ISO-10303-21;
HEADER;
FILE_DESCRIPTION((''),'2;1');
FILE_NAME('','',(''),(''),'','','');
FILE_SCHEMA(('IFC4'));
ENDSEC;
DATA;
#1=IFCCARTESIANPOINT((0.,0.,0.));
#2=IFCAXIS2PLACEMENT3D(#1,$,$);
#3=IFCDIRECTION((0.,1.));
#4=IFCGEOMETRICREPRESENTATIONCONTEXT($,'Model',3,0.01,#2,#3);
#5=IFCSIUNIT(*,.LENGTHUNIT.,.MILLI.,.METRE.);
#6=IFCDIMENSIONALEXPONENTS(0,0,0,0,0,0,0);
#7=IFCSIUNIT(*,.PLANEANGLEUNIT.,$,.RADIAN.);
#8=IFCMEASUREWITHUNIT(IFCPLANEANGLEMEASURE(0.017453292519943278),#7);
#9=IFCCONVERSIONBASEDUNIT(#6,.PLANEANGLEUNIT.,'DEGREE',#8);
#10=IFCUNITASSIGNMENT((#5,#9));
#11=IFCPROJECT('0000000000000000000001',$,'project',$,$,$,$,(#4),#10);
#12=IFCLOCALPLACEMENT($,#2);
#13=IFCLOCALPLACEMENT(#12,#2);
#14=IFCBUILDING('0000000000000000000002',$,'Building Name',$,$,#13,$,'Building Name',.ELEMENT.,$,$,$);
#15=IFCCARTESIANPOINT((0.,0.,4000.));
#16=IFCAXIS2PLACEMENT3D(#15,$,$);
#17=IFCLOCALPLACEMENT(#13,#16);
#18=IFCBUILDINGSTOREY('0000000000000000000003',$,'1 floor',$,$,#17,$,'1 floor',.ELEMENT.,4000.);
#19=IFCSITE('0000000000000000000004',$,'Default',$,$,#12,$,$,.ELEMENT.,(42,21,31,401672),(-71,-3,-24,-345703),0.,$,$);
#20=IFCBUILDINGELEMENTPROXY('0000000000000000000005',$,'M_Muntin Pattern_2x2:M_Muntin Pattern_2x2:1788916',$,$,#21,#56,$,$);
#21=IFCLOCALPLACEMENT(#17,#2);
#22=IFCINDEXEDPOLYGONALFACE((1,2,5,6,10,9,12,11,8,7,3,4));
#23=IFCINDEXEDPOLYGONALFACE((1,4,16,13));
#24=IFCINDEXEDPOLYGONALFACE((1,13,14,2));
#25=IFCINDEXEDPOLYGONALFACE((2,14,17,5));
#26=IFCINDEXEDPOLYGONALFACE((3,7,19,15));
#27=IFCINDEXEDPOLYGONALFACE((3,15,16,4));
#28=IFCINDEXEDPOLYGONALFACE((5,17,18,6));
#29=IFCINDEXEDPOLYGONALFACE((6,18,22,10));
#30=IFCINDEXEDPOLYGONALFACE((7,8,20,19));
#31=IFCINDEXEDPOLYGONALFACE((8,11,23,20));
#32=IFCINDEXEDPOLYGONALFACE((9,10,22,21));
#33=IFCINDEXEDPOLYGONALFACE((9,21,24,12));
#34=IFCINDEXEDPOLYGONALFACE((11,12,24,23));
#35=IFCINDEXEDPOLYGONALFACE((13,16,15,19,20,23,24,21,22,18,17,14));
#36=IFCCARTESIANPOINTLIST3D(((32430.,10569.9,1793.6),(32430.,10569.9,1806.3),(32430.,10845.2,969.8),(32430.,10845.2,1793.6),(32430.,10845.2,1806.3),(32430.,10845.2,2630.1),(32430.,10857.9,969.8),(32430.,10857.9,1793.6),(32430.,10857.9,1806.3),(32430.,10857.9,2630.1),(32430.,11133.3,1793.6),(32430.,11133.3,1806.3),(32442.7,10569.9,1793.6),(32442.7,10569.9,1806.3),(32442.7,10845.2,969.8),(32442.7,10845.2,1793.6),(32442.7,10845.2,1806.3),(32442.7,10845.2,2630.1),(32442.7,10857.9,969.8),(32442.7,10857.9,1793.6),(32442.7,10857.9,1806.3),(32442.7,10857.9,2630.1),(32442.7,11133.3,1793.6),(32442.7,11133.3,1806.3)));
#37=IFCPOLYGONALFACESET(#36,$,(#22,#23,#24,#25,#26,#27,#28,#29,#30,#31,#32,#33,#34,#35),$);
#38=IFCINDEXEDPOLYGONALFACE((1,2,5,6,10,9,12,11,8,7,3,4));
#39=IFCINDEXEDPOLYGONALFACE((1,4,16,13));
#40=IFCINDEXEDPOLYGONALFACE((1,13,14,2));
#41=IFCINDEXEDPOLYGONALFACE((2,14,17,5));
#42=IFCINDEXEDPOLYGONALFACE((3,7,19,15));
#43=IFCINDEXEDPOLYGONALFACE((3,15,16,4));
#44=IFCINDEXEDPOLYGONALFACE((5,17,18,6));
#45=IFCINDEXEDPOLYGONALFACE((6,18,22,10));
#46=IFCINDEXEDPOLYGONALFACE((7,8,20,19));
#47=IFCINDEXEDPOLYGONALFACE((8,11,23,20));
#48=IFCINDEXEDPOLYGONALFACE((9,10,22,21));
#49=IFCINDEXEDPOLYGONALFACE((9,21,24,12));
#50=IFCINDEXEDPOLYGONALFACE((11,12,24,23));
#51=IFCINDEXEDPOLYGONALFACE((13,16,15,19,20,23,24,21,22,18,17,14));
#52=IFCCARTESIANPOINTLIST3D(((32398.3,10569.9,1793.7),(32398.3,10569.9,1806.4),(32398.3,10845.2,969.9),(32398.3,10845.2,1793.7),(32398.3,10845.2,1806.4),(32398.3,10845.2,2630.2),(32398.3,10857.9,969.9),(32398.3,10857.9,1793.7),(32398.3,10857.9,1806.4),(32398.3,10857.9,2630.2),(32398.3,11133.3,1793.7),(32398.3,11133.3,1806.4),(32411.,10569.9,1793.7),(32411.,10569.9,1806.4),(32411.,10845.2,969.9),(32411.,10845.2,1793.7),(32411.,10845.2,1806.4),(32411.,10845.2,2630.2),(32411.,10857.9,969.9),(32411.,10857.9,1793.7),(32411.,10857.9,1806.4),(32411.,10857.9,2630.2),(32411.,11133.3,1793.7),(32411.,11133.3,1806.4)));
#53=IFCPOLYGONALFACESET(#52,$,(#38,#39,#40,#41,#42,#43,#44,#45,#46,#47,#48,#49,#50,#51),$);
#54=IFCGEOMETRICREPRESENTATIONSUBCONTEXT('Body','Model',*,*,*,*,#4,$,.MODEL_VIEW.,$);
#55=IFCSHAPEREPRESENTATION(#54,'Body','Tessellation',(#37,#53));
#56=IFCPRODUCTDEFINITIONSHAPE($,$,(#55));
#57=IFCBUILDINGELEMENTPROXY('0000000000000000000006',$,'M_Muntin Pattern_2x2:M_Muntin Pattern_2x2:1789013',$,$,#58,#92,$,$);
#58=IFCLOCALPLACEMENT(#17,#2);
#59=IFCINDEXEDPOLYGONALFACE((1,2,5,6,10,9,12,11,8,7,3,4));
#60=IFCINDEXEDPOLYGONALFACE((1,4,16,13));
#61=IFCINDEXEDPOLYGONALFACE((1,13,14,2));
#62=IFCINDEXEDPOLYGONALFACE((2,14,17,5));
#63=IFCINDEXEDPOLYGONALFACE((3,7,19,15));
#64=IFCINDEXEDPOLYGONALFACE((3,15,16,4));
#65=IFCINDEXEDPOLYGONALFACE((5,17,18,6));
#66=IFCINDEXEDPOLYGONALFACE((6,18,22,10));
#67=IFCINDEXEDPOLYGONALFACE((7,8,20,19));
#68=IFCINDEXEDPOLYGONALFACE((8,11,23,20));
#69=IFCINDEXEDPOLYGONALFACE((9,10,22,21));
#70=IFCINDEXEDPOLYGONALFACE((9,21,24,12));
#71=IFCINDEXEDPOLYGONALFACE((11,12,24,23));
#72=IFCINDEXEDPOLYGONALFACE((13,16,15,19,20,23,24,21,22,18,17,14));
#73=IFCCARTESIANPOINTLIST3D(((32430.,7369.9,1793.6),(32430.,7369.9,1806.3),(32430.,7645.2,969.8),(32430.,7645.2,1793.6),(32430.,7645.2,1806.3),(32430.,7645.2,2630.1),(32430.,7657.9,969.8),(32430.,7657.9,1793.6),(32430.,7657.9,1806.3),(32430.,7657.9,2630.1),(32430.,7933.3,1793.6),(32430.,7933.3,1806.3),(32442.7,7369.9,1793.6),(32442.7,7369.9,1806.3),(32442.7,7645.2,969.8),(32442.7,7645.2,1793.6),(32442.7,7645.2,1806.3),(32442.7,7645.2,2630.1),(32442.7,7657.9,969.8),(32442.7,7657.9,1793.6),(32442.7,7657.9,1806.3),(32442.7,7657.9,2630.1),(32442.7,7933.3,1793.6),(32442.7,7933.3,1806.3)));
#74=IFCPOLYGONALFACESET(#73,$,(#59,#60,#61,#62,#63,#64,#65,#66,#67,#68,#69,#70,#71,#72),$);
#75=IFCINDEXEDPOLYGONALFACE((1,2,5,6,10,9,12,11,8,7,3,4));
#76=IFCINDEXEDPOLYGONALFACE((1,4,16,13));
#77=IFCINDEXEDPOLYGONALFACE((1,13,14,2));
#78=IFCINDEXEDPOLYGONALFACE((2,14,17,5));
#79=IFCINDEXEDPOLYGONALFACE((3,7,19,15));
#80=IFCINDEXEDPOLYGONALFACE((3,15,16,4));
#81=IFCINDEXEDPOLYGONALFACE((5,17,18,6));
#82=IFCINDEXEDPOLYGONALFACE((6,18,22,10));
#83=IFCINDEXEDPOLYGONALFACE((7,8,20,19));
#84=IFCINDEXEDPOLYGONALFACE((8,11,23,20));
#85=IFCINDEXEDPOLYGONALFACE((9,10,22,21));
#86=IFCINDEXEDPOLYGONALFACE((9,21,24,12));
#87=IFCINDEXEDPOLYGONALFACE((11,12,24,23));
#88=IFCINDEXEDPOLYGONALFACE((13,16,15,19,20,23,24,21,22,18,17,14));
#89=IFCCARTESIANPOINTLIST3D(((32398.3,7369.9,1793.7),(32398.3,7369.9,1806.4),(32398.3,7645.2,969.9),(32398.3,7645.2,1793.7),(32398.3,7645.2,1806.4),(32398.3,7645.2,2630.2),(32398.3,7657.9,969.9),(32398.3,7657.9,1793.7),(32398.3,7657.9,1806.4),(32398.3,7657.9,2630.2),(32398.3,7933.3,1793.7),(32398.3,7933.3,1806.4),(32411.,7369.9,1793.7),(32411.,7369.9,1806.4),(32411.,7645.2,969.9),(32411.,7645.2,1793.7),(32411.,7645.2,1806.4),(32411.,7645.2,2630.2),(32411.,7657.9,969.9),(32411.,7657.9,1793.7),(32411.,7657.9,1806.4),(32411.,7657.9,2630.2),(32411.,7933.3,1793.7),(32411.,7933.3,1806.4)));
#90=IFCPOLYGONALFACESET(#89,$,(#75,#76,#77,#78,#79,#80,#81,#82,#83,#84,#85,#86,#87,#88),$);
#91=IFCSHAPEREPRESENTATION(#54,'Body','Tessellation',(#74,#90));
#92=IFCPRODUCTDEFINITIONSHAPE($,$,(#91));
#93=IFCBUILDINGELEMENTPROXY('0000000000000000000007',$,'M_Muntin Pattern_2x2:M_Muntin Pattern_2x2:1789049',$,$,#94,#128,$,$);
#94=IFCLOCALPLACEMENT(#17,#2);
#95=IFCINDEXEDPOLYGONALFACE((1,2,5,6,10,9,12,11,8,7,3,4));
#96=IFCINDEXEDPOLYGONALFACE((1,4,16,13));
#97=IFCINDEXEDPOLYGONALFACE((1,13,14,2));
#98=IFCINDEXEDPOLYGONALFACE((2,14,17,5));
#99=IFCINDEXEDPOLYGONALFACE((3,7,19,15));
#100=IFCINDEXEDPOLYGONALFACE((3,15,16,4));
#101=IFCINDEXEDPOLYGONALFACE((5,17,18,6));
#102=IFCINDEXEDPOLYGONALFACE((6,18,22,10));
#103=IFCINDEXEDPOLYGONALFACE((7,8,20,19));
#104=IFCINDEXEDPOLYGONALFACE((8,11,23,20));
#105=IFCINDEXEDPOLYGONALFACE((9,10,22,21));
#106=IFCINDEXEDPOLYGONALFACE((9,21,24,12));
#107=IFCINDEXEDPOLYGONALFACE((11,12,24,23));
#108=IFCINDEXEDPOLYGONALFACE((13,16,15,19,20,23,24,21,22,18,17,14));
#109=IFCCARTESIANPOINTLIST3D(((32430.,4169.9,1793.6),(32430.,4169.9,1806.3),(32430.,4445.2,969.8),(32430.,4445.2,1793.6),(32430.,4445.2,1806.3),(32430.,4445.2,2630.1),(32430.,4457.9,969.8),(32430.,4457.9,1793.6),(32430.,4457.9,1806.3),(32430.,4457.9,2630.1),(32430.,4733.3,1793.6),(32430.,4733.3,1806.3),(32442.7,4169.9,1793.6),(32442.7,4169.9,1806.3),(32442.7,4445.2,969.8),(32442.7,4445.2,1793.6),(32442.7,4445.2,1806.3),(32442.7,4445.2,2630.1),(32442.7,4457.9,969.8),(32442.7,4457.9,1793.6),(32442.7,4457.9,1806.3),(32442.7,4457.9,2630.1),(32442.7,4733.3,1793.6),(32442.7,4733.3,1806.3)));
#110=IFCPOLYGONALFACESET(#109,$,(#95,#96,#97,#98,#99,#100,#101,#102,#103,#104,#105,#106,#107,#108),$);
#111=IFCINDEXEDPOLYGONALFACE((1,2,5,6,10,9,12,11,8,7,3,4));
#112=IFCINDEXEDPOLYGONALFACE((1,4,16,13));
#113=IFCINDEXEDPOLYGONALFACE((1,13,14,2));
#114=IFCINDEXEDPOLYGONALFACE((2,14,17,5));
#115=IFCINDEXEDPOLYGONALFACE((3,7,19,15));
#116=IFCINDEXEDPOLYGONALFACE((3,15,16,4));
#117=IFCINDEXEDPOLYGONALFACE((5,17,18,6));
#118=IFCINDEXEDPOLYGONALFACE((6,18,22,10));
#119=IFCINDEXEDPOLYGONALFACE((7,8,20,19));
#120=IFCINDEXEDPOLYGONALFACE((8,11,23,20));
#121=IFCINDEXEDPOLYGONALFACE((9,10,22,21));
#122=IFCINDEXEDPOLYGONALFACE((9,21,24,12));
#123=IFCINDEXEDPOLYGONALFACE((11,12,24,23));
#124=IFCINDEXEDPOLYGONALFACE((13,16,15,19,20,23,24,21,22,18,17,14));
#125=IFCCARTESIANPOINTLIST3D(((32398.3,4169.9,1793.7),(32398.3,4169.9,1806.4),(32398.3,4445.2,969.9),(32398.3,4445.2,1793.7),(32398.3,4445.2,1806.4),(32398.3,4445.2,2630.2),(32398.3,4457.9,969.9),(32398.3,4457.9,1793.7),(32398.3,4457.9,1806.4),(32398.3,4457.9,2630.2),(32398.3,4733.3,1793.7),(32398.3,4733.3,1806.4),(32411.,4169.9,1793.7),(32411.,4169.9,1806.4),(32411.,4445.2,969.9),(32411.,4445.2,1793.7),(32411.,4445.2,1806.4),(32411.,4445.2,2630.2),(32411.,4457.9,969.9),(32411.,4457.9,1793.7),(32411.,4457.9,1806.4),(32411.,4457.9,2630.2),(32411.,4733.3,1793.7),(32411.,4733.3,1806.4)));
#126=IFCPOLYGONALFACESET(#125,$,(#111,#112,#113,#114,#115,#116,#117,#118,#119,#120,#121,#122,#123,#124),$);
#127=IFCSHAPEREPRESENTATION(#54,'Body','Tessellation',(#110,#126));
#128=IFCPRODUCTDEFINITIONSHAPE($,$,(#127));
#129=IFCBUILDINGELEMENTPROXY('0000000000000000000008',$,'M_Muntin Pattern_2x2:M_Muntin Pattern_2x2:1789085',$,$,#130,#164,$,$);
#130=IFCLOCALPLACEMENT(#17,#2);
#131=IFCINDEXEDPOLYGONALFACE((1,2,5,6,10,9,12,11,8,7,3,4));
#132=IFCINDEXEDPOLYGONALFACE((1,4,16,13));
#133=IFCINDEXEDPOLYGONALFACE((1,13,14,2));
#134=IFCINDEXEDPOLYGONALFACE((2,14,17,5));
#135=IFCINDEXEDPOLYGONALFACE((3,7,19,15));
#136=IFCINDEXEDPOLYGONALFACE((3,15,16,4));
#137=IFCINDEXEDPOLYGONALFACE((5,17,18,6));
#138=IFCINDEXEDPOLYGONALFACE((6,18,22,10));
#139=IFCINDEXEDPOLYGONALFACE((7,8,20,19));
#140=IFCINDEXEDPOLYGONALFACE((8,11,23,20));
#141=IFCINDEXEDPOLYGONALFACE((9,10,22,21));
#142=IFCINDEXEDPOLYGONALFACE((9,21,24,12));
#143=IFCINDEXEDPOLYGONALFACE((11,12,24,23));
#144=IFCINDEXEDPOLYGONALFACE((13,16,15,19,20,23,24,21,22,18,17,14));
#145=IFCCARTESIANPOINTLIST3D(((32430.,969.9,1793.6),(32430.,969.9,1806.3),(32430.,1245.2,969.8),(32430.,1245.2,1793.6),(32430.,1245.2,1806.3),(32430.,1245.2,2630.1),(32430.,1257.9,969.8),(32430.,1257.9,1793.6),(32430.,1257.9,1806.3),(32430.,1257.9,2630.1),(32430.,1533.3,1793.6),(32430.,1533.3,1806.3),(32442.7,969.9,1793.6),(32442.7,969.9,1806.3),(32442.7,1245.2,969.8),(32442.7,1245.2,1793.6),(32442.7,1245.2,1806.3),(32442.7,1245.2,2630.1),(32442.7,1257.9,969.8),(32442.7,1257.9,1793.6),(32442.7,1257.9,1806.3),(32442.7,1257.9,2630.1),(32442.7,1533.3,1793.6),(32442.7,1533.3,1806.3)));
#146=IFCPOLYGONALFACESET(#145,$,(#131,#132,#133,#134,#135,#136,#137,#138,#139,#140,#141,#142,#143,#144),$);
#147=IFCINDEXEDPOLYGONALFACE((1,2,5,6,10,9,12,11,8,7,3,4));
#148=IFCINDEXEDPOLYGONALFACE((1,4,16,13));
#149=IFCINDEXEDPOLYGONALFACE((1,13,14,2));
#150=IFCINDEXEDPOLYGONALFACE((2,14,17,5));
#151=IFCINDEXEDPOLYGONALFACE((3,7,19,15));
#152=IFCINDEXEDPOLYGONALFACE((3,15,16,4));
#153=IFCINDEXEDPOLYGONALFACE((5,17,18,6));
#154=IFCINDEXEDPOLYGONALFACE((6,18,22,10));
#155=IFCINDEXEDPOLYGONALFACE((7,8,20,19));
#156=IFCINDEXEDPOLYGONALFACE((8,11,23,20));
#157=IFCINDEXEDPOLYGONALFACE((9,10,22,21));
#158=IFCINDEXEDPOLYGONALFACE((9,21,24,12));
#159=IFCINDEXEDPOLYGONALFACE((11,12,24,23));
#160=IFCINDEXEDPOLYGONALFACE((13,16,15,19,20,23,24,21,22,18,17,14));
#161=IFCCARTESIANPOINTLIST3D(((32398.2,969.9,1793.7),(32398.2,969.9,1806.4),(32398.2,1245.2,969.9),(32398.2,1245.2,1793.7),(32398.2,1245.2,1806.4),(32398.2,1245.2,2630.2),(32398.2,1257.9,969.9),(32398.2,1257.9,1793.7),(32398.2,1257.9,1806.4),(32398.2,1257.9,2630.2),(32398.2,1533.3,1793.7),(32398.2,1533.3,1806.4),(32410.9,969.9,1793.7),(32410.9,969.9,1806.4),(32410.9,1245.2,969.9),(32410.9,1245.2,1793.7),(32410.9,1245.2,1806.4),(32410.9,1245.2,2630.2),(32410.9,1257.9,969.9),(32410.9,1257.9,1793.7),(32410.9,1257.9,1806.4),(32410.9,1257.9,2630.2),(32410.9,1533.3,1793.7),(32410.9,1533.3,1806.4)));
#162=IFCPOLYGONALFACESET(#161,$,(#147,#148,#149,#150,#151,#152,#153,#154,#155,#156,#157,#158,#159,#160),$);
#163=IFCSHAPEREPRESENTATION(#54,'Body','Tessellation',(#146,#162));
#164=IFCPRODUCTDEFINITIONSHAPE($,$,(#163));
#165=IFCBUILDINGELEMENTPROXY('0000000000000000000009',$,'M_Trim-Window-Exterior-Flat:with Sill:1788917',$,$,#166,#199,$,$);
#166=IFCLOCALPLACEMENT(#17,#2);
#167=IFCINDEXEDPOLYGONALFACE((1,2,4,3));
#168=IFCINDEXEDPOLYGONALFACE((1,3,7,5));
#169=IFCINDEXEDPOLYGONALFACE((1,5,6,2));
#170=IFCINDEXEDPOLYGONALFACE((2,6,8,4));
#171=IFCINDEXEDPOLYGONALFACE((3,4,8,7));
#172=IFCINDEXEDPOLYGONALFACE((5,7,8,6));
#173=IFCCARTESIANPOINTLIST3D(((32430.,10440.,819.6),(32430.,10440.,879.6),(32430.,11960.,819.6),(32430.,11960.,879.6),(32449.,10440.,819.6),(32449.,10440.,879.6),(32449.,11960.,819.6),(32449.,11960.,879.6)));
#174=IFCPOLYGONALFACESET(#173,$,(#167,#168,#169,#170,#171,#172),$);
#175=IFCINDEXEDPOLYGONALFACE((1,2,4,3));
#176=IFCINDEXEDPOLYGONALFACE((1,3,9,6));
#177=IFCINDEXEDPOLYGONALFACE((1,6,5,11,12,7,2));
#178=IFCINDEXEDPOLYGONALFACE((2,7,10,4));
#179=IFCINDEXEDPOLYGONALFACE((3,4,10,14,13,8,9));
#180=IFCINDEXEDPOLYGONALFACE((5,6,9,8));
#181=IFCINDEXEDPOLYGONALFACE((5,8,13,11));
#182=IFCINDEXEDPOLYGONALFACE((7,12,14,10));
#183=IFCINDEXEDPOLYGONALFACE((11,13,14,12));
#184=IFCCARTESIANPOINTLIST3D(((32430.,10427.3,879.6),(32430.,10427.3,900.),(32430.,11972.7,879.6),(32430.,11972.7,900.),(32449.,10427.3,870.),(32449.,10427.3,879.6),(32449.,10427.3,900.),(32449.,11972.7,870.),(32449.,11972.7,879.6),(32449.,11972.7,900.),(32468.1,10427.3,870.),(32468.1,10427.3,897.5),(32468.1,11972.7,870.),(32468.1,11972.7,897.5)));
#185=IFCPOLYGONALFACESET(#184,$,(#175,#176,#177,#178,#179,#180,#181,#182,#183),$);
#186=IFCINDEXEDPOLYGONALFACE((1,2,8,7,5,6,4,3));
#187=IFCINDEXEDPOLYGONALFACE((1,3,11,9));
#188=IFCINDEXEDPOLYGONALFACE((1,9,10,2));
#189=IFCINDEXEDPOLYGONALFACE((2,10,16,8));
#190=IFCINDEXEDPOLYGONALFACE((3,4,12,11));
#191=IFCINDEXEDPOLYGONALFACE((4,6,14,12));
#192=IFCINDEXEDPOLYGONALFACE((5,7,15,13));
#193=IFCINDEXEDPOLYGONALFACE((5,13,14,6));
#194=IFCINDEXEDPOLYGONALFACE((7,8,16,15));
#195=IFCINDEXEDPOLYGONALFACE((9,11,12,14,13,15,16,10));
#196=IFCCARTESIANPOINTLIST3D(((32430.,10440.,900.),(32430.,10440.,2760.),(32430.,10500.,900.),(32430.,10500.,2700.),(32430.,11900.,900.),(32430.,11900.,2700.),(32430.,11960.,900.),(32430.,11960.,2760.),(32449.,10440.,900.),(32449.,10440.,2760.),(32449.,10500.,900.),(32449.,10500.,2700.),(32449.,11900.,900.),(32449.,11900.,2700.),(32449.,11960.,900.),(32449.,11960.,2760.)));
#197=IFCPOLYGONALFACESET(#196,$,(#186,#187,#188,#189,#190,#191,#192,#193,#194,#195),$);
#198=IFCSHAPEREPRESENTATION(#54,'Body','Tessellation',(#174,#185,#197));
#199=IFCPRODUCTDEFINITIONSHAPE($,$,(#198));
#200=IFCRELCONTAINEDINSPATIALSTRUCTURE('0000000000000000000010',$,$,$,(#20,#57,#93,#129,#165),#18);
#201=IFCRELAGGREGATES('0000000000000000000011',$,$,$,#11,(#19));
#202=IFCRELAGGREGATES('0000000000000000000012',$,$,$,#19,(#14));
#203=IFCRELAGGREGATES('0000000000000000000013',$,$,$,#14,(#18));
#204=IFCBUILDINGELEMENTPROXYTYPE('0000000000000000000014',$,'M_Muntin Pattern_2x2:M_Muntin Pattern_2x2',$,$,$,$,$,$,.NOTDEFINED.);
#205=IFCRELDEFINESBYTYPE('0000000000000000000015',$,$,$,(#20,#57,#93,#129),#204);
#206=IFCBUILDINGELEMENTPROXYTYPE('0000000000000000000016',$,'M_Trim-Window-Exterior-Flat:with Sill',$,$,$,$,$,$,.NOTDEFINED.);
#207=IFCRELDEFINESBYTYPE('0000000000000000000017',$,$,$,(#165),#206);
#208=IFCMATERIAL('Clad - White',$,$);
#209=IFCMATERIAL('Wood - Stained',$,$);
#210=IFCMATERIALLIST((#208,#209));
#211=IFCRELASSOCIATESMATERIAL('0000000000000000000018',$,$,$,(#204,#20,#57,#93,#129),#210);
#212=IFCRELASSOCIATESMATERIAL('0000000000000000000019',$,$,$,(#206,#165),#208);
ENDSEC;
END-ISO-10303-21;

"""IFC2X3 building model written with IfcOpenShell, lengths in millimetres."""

from ifc_helpers import new_model, entity, si_unit, converted_unit, direction, frame, frame_2d, origin, place, context, subcontext, project, spatial, polyline, rectangle, outline, extrude, source, transform, mapped, material, material_list, type_object, type_shapes, element, save


model = new_model("IFC2X3")

# Units and contexts
model_context = context("Model", 3, precision=0.01, world=origin(), true_north=direction((0.0, 1.0)))
body_context = subcontext(model_context, "Body", "Model", "MODEL_VIEW")
ifc_project = project(units=[si_unit("LENGTHUNIT", "METRE", prefix="MILLI"), converted_unit("PLANEANGLEUNIT", "DEGREE", entity("IfcPlaneAngleMeasure", 0.017453292519943278), si_unit("PLANEANGLEUNIT", "RADIAN"), dimensions=[0, 0, 0, 0, 0, 0, 0])], contexts=[model_context])

# Site, building, storey
site_placement = place(None, origin())
site = spatial("IfcSite", under=ifc_project, at=site_placement, Name="Default", CompositionType="ELEMENT", RefLatitude=(42, 21, 31, 401672), RefLongitude=(-71, -3, -24, -345703), RefElevation=0.0)
building_placement = place(site_placement, origin())
building = spatial("IfcBuilding", under=site, at=building_placement, Name="Building Name", LongName="Building Name", CompositionType="ELEMENT")
storey_placement = place(building_placement, frame((0.0, 0.0, 4000.0)))
storey = spatial("IfcBuildingStorey", under=building, at=storey_placement, Name="1 floor", LongName="1 floor", CompositionType="ELEMENT", Elevation=4000.0)

# Building element proxies
ifc_material_1 = material(Name="Clad - White")
ifc_material_2 = material(Name="Wood - Stained")
ifc_material_list = material_list([ifc_material_1, ifc_material_2])
building_element_proxy_type_1 = type_object("IfcBuildingElementProxyType", Name="M_Muntin Pattern_2x2:M_Muntin Pattern_2x2", PredefinedType="NOTDEFINED", material=ifc_material_list)
shared_shape_1 = source(origin(), body_context, "Body", "SweptSolid", [
    extrude(outline(polyline([(6.4, -6.4), (830.1, -6.4), (830.1, 6.3), (6.4, 6.3), (6.4, 281.7), (-6.3, 281.7), (-6.3, 6.3), (-830.2, 6.3), (-830.2, -6.4), (-6.3, -6.4), (-6.3, -281.7), (6.4, -281.7), (6.4, -6.4)])), frame((0.0, -22.2, 830.1), z_axis=(0.0, 1.0, 0.0), x_axis=(0.0, 0.0, 1.0)), (0.0, 0.0, 1.0), 12.7),
    extrude(outline(polyline([(6.4, -6.4), (830.2, -6.4), (830.2, 6.3), (6.4, 6.3), (6.4, 281.7), (-6.3, 281.7), (-6.3, 6.3), (-830.2, 6.3), (-830.2, -6.4), (-6.3, -6.4), (-6.3, -281.7), (6.4, -281.7), (6.4, -6.4)])), frame((0.0, 9.5, 830.2), z_axis=(0.0, 1.0, 0.0), x_axis=(0.0, 0.0, 1.0)), (0.0, 0.0, 1.0), 12.7),
])
type_shapes(building_element_proxy_type_1, [shared_shape_1])
for number, where, z_axis, x_axis, name in (
    (1, (32420.5, 10851.6, 969.9), (0.0, 0.0, 1.0), (0.0, 1.0, 0.0), "M_Muntin Pattern_2x2:M_Muntin Pattern_2x2:1788916"),
    (2, (32420.5, 7651.6, 969.9), (0.0, 0.0, 1.0), (0.0, 1.0, 0.0), "M_Muntin Pattern_2x2:M_Muntin Pattern_2x2:1789013"),
    (3, (32420.5, 4451.6, 969.9), (0.0, 0.0, 1.0), (0.0, 1.0, 0.0), "M_Muntin Pattern_2x2:M_Muntin Pattern_2x2:1789049"),
    (4, (32420.5, 1251.6, 969.9), (0.0, 0.0, 1.0), (0.0, 1.0, 0.0), "M_Muntin Pattern_2x2:M_Muntin Pattern_2x2:1789085"),
):
    element("IfcBuildingElementProxy", number, at=place(storey_placement, frame(where, z_axis=z_axis, x_axis=x_axis)), inside=storey, type_object=building_element_proxy_type_1, material=ifc_material_list, Name=name, context=body_context, shape_type="MappedRepresentation", body=[
        mapped(shared_shape_1, transform((0.0, 0.0, 0.0), scale=1.0)),
    ])
building_element_proxy_type_2 = type_object("IfcBuildingElementProxyType", Name="M_Trim-Window-Exterior-Flat:with Sill", PredefinedType="NOTDEFINED", material=ifc_material_1)
shared_shape_2 = source(origin(), body_context, "Body", "SweptSolid", [
    extrude(rectangle(XDim=1520.0, YDim=60.0, at=frame_2d((0.0, 0.0), x_axis=(1.0, 0.0))), frame((0.0, -1850.4, 0.0), z_axis=(0.0, 0.0, 1.0), x_axis=(-1.0, 0.0, 0.0)), (0.0, 0.0, 1.0), 19.0),
    extrude(outline(polyline([(-19.0, -15.2), (0.0, -15.2), (0.0, -5.7), (19.0, -5.7), (19.0, 14.8), (0.0, 14.8), (-19.0, 12.3), (-19.0, -15.2)])), frame((-772.7, -1814.8, 19.0), z_axis=(1.0, 0.0, 0.0), x_axis=(0.0, 0.0, -1.0)), (0.0, 0.0, 1.0), 1545.4),
    extrude(outline(polyline([(-945.0, -760.0), (915.0, -760.0), (915.0, -700.0), (-885.0, -700.0), (-885.0, 700.0), (915.0, 700.0), (915.0, 760.0), (-945.0, 760.0), (-945.0, -760.0)])), frame((0.0, -885.0, 0.0), z_axis=(0.0, 0.0, 1.0), x_axis=(0.0, -1.0, 0.0)), (0.0, 0.0, 1.0), 19.0),
])
type_shapes(building_element_proxy_type_2, [shared_shape_2])
for number, where, z_axis, x_axis, name in (
    (5, (32430.0, 11200.0, 2700.0), (1.0, 0.0, 0.0), (0.0, 1.0, 0.0), "M_Trim-Window-Exterior-Flat:with Sill:1788917"),
):
    element("IfcBuildingElementProxy", number, at=place(storey_placement, frame(where, z_axis=z_axis, x_axis=x_axis)), inside=storey, type_object=building_element_proxy_type_2, material=ifc_material_1, Name=name, context=body_context, shape_type="MappedRepresentation", body=[
        mapped(shared_shape_2, transform((0.0, 0.0, 0.0), scale=1.0)),
    ])

save(model, "model.ifc")
